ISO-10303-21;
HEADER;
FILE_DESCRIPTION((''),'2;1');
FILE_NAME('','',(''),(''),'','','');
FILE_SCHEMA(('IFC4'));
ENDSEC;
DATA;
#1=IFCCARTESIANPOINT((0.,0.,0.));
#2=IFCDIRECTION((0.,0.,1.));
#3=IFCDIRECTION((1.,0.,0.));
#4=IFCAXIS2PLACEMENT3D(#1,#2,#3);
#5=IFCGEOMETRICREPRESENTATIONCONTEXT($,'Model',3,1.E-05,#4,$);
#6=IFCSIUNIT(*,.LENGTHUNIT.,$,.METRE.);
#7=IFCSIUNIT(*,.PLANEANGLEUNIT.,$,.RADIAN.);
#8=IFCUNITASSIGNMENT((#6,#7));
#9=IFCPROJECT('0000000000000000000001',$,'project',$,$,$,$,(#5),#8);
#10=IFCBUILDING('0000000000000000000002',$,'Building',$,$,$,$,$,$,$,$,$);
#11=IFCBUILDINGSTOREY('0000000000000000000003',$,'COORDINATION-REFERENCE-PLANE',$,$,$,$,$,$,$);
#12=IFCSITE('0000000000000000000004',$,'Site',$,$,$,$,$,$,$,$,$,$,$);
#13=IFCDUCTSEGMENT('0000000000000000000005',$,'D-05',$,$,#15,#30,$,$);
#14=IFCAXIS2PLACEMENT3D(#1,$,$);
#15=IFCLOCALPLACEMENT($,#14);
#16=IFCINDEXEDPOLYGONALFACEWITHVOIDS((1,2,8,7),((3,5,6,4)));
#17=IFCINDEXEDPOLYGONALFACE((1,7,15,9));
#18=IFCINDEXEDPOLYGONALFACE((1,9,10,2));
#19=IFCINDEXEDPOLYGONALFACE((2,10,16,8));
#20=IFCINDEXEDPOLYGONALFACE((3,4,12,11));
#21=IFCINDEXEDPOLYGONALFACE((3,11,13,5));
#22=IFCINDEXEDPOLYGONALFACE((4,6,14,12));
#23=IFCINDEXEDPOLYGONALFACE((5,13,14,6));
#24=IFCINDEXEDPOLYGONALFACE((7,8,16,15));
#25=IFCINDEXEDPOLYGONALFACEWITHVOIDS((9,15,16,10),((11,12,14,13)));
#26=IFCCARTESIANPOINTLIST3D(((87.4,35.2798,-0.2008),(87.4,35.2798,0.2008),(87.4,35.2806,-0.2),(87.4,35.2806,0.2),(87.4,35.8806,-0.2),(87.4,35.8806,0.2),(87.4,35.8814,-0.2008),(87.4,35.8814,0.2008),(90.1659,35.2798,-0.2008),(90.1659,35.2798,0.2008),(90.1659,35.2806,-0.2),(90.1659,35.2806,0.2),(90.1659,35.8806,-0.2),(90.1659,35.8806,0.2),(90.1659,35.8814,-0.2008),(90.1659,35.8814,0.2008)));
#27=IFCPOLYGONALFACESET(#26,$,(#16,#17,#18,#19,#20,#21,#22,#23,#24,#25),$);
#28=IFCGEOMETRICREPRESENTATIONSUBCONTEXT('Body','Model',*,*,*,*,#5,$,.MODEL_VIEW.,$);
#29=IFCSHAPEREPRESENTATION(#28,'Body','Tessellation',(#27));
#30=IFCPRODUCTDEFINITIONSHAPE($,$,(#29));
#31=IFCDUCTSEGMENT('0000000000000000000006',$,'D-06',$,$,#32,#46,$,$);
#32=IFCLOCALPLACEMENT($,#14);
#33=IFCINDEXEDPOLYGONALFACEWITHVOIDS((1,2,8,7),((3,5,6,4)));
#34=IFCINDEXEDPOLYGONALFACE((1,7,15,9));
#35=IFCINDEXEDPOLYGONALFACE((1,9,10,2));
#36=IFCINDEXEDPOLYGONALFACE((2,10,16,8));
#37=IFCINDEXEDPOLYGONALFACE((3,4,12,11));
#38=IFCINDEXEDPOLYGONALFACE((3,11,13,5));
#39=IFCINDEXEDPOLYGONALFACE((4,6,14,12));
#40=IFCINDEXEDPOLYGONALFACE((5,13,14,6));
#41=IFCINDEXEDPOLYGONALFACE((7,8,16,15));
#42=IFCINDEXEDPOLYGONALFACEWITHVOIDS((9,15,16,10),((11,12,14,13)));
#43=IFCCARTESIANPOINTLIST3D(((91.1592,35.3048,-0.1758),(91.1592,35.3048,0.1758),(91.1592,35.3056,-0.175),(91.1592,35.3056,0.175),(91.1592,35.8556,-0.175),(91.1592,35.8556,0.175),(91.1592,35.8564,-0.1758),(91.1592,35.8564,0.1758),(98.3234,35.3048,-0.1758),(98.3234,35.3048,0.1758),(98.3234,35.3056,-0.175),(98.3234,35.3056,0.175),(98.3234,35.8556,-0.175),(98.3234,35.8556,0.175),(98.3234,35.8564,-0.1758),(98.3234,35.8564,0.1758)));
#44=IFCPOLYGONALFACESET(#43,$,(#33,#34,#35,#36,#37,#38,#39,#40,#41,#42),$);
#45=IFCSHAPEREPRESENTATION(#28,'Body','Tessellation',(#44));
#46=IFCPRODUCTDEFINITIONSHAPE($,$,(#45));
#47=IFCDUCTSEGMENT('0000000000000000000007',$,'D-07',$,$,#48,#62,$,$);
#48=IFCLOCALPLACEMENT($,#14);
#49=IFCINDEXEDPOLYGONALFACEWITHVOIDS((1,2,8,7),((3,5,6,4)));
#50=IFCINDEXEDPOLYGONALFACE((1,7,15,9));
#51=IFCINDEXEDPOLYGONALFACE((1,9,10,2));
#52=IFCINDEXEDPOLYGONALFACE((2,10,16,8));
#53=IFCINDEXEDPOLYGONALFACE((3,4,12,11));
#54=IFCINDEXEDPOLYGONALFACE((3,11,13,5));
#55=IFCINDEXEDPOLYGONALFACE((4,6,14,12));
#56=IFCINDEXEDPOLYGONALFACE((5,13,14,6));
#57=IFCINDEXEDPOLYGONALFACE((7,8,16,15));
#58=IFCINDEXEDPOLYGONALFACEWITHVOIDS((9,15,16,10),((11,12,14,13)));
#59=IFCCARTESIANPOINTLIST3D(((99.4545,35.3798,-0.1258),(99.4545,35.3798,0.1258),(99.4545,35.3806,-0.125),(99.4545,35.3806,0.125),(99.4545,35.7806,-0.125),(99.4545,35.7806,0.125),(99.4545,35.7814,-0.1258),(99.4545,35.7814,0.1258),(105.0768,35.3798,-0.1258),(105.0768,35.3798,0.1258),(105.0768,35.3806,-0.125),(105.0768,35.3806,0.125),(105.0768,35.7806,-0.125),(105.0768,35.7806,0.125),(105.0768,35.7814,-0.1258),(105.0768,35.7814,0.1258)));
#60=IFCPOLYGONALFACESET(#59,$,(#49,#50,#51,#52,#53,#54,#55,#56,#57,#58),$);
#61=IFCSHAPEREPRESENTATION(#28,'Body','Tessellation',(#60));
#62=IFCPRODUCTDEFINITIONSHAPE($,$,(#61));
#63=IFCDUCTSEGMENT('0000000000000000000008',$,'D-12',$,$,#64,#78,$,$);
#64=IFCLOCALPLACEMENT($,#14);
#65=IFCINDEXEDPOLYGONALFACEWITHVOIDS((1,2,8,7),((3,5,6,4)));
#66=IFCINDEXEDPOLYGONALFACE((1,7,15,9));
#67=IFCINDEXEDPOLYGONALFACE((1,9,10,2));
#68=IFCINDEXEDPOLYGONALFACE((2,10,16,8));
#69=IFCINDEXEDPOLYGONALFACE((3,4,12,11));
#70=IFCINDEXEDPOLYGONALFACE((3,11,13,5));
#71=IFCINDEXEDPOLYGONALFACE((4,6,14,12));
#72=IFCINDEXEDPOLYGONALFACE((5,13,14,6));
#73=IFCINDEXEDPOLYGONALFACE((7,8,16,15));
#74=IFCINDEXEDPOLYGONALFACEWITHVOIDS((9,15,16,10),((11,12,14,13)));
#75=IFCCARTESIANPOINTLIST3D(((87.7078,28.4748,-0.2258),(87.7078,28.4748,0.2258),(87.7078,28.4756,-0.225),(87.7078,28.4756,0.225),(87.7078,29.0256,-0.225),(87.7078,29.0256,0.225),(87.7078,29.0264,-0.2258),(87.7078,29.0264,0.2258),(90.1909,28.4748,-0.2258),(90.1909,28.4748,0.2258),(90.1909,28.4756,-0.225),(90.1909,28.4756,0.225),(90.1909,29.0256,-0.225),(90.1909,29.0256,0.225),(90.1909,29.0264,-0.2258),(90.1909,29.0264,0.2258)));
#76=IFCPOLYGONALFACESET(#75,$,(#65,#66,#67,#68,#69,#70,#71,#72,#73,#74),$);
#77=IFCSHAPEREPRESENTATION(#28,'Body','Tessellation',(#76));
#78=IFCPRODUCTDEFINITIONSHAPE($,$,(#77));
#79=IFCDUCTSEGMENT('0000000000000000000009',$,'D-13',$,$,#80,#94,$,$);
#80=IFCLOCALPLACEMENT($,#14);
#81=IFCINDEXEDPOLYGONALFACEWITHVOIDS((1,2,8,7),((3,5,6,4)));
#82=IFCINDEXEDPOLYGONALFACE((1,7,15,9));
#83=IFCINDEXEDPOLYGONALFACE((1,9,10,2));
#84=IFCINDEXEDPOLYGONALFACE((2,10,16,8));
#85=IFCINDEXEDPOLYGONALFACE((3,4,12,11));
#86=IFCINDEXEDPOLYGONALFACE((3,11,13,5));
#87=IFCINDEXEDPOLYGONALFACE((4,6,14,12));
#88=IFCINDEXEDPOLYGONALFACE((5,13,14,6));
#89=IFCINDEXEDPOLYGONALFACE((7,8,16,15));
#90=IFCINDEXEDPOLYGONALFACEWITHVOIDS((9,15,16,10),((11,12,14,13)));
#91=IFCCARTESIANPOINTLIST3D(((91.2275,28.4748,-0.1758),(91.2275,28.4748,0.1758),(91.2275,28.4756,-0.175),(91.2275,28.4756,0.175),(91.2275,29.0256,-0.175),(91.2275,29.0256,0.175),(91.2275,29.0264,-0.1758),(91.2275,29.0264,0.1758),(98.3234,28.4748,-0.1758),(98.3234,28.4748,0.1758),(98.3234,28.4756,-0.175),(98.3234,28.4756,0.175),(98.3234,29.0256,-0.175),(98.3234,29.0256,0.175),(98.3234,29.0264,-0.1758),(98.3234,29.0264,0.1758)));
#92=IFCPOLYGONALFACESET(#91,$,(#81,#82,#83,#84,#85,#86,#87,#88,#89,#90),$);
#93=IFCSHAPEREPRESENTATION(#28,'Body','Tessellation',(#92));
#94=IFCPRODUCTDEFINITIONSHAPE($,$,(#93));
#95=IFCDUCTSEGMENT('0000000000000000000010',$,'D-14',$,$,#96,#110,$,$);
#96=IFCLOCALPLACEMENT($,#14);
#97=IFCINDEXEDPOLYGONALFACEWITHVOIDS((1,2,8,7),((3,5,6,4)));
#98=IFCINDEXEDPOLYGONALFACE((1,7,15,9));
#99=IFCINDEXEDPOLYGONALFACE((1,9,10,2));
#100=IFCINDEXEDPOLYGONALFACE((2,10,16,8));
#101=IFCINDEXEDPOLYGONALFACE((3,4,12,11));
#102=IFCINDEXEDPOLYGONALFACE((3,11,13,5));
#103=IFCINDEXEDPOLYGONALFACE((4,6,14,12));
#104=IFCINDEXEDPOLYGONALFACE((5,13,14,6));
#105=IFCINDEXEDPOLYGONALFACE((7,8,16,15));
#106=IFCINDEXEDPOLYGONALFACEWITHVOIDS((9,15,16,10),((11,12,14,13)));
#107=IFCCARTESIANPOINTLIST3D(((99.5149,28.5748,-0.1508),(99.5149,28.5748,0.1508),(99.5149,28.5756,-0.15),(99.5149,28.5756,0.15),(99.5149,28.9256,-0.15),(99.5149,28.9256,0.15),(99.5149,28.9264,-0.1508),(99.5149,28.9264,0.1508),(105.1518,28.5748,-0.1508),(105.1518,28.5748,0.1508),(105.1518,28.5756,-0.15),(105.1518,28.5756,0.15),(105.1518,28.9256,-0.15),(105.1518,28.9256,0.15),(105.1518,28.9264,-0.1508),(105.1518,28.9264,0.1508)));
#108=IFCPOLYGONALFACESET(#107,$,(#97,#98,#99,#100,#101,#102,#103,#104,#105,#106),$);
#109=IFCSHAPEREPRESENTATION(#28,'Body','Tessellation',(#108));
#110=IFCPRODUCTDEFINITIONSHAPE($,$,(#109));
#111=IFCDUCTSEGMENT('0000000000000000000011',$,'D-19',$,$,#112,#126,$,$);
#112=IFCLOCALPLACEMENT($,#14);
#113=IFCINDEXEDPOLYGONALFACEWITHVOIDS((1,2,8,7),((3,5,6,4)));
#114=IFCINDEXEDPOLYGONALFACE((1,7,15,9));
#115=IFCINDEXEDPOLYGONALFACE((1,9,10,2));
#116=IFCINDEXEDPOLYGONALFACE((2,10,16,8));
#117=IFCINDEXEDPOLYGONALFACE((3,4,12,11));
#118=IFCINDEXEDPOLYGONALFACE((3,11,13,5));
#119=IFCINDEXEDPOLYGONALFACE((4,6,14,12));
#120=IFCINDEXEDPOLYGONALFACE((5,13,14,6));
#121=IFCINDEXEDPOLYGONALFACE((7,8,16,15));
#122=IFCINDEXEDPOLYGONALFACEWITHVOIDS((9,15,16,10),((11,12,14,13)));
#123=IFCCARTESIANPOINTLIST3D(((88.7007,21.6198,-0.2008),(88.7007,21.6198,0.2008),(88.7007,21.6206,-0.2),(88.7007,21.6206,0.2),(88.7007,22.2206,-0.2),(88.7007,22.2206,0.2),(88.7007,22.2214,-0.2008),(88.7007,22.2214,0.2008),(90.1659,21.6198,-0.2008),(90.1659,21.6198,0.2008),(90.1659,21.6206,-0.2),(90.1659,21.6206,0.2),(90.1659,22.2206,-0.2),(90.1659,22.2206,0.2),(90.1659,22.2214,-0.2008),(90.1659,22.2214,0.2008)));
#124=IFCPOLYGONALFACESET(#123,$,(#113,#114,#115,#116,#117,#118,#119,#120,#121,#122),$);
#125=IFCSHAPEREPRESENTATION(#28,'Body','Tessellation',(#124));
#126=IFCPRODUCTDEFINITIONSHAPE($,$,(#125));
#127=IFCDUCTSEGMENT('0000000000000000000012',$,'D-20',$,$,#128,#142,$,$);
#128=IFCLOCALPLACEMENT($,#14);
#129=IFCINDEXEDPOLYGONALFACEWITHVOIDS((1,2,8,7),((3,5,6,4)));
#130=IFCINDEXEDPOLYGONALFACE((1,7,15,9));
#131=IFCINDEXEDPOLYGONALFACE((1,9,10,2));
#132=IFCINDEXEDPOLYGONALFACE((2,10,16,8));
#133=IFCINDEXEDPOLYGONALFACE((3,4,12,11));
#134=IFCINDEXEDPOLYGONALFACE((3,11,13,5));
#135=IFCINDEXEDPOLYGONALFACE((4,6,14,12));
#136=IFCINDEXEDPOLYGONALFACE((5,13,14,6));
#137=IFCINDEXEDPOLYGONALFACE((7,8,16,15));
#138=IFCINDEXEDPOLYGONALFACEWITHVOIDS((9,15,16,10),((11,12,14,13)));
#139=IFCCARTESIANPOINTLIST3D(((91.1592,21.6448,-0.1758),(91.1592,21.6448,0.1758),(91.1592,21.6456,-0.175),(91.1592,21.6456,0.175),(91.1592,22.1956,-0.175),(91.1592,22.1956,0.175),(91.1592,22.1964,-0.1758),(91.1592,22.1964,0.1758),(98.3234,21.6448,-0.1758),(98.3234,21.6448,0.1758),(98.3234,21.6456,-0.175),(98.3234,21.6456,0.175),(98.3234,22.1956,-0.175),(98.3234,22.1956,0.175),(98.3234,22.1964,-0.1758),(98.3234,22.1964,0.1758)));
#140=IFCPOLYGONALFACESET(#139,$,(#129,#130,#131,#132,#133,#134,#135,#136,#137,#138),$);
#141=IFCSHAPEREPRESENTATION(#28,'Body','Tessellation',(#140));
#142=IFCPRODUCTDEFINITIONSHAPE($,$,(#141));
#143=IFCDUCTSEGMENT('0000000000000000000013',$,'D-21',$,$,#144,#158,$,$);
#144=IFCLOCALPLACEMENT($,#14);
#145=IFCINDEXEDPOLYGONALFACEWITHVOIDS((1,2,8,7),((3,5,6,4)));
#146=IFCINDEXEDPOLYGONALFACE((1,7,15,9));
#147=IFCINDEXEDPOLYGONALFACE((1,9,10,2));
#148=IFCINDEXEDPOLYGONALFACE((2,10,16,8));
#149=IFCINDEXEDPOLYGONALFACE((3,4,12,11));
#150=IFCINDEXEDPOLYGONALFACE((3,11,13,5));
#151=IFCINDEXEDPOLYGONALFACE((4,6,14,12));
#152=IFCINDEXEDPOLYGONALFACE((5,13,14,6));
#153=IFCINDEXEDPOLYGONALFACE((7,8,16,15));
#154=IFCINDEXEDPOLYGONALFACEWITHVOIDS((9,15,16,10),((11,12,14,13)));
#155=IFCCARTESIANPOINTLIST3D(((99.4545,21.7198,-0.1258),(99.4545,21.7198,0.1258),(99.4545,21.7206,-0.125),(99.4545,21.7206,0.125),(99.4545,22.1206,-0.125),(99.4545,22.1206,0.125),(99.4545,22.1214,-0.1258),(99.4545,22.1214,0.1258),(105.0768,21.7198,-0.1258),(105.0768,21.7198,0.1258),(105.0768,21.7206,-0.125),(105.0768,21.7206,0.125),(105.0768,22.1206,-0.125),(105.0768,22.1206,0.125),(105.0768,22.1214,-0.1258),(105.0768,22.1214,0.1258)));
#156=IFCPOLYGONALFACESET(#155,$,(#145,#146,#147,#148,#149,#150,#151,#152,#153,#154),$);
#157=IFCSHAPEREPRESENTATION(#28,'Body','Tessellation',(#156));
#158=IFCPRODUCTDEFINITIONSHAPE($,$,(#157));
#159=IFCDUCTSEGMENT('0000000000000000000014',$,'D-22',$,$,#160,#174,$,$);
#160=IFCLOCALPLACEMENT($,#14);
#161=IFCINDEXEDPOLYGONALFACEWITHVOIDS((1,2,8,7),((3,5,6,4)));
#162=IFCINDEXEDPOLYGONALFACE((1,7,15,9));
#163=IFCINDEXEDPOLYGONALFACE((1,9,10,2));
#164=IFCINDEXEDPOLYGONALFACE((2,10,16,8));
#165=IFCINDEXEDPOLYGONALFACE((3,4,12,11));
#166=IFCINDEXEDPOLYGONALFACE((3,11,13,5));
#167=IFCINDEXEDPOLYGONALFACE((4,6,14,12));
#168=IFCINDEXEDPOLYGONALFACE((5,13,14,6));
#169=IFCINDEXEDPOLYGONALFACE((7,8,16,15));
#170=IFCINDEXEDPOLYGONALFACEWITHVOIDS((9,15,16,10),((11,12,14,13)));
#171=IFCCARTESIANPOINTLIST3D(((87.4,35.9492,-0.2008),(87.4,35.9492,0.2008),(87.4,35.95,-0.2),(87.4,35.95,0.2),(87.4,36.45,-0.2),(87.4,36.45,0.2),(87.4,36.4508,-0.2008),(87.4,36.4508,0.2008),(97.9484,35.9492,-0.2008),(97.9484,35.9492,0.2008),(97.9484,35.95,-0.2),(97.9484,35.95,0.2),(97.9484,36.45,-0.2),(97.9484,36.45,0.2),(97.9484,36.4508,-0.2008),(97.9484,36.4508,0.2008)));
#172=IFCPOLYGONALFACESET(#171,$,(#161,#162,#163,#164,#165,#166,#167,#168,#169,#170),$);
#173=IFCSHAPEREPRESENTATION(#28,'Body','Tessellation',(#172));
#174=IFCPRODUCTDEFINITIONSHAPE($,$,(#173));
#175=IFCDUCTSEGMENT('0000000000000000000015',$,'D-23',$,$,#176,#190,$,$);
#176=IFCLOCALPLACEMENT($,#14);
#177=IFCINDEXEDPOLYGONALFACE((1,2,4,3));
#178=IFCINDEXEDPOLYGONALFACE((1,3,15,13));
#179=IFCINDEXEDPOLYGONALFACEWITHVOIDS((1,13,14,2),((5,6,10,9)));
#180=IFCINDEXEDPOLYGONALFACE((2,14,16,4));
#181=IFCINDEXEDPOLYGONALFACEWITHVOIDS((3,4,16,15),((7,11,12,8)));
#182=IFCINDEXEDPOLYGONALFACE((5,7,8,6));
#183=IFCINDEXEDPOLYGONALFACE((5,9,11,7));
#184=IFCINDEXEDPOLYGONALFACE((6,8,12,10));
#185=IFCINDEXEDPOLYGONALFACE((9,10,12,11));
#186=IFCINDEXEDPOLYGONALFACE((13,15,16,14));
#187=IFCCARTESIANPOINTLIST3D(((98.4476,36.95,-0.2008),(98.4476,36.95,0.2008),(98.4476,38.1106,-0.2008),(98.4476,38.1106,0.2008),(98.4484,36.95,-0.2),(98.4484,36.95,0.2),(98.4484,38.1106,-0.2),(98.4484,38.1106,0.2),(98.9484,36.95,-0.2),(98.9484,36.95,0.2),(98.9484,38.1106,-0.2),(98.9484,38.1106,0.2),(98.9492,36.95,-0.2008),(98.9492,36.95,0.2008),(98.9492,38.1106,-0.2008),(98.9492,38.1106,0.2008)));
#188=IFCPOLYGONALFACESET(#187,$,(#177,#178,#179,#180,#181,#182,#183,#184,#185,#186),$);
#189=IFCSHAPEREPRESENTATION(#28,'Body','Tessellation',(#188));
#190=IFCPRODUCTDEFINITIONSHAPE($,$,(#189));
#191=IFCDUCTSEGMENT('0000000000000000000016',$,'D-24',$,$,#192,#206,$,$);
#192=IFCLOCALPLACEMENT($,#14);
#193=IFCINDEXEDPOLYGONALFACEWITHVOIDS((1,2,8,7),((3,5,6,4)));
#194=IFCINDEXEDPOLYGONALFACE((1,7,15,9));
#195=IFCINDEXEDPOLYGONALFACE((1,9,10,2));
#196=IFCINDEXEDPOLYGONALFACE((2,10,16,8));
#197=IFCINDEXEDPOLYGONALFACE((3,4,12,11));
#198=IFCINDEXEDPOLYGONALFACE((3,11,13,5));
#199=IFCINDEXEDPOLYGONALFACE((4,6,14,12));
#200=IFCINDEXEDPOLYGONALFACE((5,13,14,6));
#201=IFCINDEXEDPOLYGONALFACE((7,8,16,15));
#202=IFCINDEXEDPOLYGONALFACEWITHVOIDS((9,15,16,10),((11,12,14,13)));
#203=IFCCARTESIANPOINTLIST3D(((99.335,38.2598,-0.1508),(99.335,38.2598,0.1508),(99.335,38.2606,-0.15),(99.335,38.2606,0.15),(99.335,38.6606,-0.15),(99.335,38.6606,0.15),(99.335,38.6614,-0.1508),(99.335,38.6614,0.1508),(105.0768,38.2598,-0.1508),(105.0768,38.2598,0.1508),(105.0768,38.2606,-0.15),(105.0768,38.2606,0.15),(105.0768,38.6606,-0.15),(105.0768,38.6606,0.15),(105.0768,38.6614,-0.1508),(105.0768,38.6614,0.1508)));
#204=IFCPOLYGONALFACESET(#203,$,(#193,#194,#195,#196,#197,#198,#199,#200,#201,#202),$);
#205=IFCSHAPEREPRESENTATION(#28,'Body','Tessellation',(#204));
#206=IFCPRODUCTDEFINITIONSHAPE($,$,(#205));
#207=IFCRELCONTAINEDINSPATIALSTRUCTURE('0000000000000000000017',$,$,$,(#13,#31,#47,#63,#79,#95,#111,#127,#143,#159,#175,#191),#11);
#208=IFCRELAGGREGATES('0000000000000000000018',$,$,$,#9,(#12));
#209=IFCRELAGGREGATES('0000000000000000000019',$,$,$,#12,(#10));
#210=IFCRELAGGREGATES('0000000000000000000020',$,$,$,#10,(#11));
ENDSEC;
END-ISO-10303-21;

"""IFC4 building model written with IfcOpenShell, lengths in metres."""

from ifc_helpers import new_model, si_unit, frame, origin, origin_with_axes, place, context, subcontext, project, spatial, hollow_rectangle, extrude, element, save


model = new_model("IFC4")

# Units and contexts
model_context = context("Model", 3, precision=1e-05, world=origin_with_axes())
body_context = subcontext(model_context, "Body", "Model", "MODEL_VIEW")
ifc_project = project(units=[si_unit("LENGTHUNIT", "METRE"), si_unit("PLANEANGLEUNIT", "RADIAN")], contexts=[model_context])

# Site, building, storey
site = spatial("IfcSite", under=ifc_project, Name="Site")
building = spatial("IfcBuilding", under=site, Name="Building")
storey = spatial("IfcBuildingStorey", under=building, Name="COORDINATION-REFERENCE-PLANE")

# Duct segments
duct_segment_1_placement = place(None, frame((87.4, 35.5806, 0.0), z_axis=(1.0, 0.0, 0.0), x_axis=(0.0, 1.0, 0.0)))
element("IfcDuctSegment", 1, at=duct_segment_1_placement, inside=storey, Name="D-05", context=body_context, shape_type="SweptSolid", body=[
    extrude(hollow_rectangle(XDim=0.6016, YDim=0.4016, WallThickness=0.0008), origin(), (0.0, 0.0, 1.0), 2.7659),
])
duct_segment_2_placement = place(None, frame((91.1592, 35.5806, 0.0), z_axis=(1.0, 0.0, 0.0), x_axis=(0.0, 1.0, 0.0)))
element("IfcDuctSegment", 2, at=duct_segment_2_placement, inside=storey, Name="D-06", context=body_context, shape_type="SweptSolid", body=[
    extrude(hollow_rectangle(XDim=0.5516, YDim=0.3516, WallThickness=0.0008), origin(), (0.0, 0.0, 1.0), 7.1642),
])
duct_segment_3_placement = place(None, frame((99.4545, 35.5806, 0.0), z_axis=(1.0, 0.0, 0.0), x_axis=(0.0, 1.0, 0.0)))
element("IfcDuctSegment", 3, at=duct_segment_3_placement, inside=storey, Name="D-07", context=body_context, shape_type="SweptSolid", body=[
    extrude(hollow_rectangle(XDim=0.4016, YDim=0.2516, WallThickness=0.0008), origin(), (0.0, 0.0, 1.0), 5.6223),
])
duct_segment_4_placement = place(None, frame((87.7078, 28.7506, 0.0), z_axis=(1.0, 0.0, 0.0), x_axis=(0.0, 1.0, 0.0)))
element("IfcDuctSegment", 4, at=duct_segment_4_placement, inside=storey, Name="D-12", context=body_context, shape_type="SweptSolid", body=[
    extrude(hollow_rectangle(XDim=0.5516, YDim=0.4516, WallThickness=0.0008), origin(), (0.0, 0.0, 1.0), 2.4831),
])
duct_segment_5_placement = place(None, frame((91.2275, 28.7506, 0.0), z_axis=(1.0, 0.0, 0.0), x_axis=(0.0, 1.0, 0.0)))
element("IfcDuctSegment", 5, at=duct_segment_5_placement, inside=storey, Name="D-13", context=body_context, shape_type="SweptSolid", body=[
    extrude(hollow_rectangle(XDim=0.5516, YDim=0.3516, WallThickness=0.0008), origin(), (0.0, 0.0, 1.0), 7.0959),
])
duct_segment_6_placement = place(None, frame((99.5149, 28.7506, 0.0), z_axis=(1.0, 0.0, 0.0), x_axis=(0.0, 1.0, 0.0)))
element("IfcDuctSegment", 6, at=duct_segment_6_placement, inside=storey, Name="D-14", context=body_context, shape_type="SweptSolid", body=[
    extrude(hollow_rectangle(XDim=0.3516, YDim=0.3016, WallThickness=0.0008), origin(), (0.0, 0.0, 1.0), 5.6369),
])
duct_segment_7_placement = place(None, frame((88.7007, 21.9206, 0.0), z_axis=(1.0, 0.0, 0.0), x_axis=(0.0, 1.0, 0.0)))
element("IfcDuctSegment", 7, at=duct_segment_7_placement, inside=storey, Name="D-19", context=body_context, shape_type="SweptSolid", body=[
    extrude(hollow_rectangle(XDim=0.6016, YDim=0.4016, WallThickness=0.0008), origin(), (0.0, 0.0, 1.0), 1.4652),
])
duct_segment_8_placement = place(None, frame((91.1592, 21.9206, 0.0), z_axis=(1.0, 0.0, 0.0), x_axis=(0.0, 1.0, 0.0)))
element("IfcDuctSegment", 8, at=duct_segment_8_placement, inside=storey, Name="D-20", context=body_context, shape_type="SweptSolid", body=[
    extrude(hollow_rectangle(XDim=0.5516, YDim=0.3516, WallThickness=0.0008), origin(), (0.0, 0.0, 1.0), 7.1642),
])
duct_segment_9_placement = place(None, frame((99.4545, 21.9206, 0.0), z_axis=(1.0, 0.0, 0.0), x_axis=(0.0, 1.0, 0.0)))
element("IfcDuctSegment", 9, at=duct_segment_9_placement, inside=storey, Name="D-21", context=body_context, shape_type="SweptSolid", body=[
    extrude(hollow_rectangle(XDim=0.4016, YDim=0.2516, WallThickness=0.0008), origin(), (0.0, 0.0, 1.0), 5.6223),
])
duct_segment_10_placement = place(None, frame((87.4, 36.2, 0.0), z_axis=(1.0, 0.0, 0.0), x_axis=(0.0, 1.0, 0.0)))
element("IfcDuctSegment", 10, at=duct_segment_10_placement, inside=storey, Name="D-22", context=body_context, shape_type="SweptSolid", body=[
    extrude(hollow_rectangle(XDim=0.5016, YDim=0.4016, WallThickness=0.0008), origin(), (0.0, 0.0, 1.0), 10.5484),
])
duct_segment_11_placement = place(None, frame((98.6984, 36.95, 0.0), z_axis=(0.0, 1.0, 0.0), x_axis=(1.0, 0.0, 0.0)))
element("IfcDuctSegment", 11, at=duct_segment_11_placement, inside=storey, Name="D-23", context=body_context, shape_type="SweptSolid", body=[
    extrude(hollow_rectangle(XDim=0.5016, YDim=0.4016, WallThickness=0.0008), origin(), (0.0, 0.0, 1.0), 1.1606),
])
duct_segment_12_placement = place(None, frame((99.335, 38.4606, 0.0), z_axis=(1.0, 0.0, 0.0), x_axis=(0.0, 1.0, 0.0)))
element("IfcDuctSegment", 12, at=duct_segment_12_placement, inside=storey, Name="D-24", context=body_context, shape_type="SweptSolid", body=[
    extrude(hollow_rectangle(XDim=0.4016, YDim=0.3016, WallThickness=0.0008), origin(), (0.0, 0.0, 1.0), 5.7417),
])

save(model, "model.ifc")
